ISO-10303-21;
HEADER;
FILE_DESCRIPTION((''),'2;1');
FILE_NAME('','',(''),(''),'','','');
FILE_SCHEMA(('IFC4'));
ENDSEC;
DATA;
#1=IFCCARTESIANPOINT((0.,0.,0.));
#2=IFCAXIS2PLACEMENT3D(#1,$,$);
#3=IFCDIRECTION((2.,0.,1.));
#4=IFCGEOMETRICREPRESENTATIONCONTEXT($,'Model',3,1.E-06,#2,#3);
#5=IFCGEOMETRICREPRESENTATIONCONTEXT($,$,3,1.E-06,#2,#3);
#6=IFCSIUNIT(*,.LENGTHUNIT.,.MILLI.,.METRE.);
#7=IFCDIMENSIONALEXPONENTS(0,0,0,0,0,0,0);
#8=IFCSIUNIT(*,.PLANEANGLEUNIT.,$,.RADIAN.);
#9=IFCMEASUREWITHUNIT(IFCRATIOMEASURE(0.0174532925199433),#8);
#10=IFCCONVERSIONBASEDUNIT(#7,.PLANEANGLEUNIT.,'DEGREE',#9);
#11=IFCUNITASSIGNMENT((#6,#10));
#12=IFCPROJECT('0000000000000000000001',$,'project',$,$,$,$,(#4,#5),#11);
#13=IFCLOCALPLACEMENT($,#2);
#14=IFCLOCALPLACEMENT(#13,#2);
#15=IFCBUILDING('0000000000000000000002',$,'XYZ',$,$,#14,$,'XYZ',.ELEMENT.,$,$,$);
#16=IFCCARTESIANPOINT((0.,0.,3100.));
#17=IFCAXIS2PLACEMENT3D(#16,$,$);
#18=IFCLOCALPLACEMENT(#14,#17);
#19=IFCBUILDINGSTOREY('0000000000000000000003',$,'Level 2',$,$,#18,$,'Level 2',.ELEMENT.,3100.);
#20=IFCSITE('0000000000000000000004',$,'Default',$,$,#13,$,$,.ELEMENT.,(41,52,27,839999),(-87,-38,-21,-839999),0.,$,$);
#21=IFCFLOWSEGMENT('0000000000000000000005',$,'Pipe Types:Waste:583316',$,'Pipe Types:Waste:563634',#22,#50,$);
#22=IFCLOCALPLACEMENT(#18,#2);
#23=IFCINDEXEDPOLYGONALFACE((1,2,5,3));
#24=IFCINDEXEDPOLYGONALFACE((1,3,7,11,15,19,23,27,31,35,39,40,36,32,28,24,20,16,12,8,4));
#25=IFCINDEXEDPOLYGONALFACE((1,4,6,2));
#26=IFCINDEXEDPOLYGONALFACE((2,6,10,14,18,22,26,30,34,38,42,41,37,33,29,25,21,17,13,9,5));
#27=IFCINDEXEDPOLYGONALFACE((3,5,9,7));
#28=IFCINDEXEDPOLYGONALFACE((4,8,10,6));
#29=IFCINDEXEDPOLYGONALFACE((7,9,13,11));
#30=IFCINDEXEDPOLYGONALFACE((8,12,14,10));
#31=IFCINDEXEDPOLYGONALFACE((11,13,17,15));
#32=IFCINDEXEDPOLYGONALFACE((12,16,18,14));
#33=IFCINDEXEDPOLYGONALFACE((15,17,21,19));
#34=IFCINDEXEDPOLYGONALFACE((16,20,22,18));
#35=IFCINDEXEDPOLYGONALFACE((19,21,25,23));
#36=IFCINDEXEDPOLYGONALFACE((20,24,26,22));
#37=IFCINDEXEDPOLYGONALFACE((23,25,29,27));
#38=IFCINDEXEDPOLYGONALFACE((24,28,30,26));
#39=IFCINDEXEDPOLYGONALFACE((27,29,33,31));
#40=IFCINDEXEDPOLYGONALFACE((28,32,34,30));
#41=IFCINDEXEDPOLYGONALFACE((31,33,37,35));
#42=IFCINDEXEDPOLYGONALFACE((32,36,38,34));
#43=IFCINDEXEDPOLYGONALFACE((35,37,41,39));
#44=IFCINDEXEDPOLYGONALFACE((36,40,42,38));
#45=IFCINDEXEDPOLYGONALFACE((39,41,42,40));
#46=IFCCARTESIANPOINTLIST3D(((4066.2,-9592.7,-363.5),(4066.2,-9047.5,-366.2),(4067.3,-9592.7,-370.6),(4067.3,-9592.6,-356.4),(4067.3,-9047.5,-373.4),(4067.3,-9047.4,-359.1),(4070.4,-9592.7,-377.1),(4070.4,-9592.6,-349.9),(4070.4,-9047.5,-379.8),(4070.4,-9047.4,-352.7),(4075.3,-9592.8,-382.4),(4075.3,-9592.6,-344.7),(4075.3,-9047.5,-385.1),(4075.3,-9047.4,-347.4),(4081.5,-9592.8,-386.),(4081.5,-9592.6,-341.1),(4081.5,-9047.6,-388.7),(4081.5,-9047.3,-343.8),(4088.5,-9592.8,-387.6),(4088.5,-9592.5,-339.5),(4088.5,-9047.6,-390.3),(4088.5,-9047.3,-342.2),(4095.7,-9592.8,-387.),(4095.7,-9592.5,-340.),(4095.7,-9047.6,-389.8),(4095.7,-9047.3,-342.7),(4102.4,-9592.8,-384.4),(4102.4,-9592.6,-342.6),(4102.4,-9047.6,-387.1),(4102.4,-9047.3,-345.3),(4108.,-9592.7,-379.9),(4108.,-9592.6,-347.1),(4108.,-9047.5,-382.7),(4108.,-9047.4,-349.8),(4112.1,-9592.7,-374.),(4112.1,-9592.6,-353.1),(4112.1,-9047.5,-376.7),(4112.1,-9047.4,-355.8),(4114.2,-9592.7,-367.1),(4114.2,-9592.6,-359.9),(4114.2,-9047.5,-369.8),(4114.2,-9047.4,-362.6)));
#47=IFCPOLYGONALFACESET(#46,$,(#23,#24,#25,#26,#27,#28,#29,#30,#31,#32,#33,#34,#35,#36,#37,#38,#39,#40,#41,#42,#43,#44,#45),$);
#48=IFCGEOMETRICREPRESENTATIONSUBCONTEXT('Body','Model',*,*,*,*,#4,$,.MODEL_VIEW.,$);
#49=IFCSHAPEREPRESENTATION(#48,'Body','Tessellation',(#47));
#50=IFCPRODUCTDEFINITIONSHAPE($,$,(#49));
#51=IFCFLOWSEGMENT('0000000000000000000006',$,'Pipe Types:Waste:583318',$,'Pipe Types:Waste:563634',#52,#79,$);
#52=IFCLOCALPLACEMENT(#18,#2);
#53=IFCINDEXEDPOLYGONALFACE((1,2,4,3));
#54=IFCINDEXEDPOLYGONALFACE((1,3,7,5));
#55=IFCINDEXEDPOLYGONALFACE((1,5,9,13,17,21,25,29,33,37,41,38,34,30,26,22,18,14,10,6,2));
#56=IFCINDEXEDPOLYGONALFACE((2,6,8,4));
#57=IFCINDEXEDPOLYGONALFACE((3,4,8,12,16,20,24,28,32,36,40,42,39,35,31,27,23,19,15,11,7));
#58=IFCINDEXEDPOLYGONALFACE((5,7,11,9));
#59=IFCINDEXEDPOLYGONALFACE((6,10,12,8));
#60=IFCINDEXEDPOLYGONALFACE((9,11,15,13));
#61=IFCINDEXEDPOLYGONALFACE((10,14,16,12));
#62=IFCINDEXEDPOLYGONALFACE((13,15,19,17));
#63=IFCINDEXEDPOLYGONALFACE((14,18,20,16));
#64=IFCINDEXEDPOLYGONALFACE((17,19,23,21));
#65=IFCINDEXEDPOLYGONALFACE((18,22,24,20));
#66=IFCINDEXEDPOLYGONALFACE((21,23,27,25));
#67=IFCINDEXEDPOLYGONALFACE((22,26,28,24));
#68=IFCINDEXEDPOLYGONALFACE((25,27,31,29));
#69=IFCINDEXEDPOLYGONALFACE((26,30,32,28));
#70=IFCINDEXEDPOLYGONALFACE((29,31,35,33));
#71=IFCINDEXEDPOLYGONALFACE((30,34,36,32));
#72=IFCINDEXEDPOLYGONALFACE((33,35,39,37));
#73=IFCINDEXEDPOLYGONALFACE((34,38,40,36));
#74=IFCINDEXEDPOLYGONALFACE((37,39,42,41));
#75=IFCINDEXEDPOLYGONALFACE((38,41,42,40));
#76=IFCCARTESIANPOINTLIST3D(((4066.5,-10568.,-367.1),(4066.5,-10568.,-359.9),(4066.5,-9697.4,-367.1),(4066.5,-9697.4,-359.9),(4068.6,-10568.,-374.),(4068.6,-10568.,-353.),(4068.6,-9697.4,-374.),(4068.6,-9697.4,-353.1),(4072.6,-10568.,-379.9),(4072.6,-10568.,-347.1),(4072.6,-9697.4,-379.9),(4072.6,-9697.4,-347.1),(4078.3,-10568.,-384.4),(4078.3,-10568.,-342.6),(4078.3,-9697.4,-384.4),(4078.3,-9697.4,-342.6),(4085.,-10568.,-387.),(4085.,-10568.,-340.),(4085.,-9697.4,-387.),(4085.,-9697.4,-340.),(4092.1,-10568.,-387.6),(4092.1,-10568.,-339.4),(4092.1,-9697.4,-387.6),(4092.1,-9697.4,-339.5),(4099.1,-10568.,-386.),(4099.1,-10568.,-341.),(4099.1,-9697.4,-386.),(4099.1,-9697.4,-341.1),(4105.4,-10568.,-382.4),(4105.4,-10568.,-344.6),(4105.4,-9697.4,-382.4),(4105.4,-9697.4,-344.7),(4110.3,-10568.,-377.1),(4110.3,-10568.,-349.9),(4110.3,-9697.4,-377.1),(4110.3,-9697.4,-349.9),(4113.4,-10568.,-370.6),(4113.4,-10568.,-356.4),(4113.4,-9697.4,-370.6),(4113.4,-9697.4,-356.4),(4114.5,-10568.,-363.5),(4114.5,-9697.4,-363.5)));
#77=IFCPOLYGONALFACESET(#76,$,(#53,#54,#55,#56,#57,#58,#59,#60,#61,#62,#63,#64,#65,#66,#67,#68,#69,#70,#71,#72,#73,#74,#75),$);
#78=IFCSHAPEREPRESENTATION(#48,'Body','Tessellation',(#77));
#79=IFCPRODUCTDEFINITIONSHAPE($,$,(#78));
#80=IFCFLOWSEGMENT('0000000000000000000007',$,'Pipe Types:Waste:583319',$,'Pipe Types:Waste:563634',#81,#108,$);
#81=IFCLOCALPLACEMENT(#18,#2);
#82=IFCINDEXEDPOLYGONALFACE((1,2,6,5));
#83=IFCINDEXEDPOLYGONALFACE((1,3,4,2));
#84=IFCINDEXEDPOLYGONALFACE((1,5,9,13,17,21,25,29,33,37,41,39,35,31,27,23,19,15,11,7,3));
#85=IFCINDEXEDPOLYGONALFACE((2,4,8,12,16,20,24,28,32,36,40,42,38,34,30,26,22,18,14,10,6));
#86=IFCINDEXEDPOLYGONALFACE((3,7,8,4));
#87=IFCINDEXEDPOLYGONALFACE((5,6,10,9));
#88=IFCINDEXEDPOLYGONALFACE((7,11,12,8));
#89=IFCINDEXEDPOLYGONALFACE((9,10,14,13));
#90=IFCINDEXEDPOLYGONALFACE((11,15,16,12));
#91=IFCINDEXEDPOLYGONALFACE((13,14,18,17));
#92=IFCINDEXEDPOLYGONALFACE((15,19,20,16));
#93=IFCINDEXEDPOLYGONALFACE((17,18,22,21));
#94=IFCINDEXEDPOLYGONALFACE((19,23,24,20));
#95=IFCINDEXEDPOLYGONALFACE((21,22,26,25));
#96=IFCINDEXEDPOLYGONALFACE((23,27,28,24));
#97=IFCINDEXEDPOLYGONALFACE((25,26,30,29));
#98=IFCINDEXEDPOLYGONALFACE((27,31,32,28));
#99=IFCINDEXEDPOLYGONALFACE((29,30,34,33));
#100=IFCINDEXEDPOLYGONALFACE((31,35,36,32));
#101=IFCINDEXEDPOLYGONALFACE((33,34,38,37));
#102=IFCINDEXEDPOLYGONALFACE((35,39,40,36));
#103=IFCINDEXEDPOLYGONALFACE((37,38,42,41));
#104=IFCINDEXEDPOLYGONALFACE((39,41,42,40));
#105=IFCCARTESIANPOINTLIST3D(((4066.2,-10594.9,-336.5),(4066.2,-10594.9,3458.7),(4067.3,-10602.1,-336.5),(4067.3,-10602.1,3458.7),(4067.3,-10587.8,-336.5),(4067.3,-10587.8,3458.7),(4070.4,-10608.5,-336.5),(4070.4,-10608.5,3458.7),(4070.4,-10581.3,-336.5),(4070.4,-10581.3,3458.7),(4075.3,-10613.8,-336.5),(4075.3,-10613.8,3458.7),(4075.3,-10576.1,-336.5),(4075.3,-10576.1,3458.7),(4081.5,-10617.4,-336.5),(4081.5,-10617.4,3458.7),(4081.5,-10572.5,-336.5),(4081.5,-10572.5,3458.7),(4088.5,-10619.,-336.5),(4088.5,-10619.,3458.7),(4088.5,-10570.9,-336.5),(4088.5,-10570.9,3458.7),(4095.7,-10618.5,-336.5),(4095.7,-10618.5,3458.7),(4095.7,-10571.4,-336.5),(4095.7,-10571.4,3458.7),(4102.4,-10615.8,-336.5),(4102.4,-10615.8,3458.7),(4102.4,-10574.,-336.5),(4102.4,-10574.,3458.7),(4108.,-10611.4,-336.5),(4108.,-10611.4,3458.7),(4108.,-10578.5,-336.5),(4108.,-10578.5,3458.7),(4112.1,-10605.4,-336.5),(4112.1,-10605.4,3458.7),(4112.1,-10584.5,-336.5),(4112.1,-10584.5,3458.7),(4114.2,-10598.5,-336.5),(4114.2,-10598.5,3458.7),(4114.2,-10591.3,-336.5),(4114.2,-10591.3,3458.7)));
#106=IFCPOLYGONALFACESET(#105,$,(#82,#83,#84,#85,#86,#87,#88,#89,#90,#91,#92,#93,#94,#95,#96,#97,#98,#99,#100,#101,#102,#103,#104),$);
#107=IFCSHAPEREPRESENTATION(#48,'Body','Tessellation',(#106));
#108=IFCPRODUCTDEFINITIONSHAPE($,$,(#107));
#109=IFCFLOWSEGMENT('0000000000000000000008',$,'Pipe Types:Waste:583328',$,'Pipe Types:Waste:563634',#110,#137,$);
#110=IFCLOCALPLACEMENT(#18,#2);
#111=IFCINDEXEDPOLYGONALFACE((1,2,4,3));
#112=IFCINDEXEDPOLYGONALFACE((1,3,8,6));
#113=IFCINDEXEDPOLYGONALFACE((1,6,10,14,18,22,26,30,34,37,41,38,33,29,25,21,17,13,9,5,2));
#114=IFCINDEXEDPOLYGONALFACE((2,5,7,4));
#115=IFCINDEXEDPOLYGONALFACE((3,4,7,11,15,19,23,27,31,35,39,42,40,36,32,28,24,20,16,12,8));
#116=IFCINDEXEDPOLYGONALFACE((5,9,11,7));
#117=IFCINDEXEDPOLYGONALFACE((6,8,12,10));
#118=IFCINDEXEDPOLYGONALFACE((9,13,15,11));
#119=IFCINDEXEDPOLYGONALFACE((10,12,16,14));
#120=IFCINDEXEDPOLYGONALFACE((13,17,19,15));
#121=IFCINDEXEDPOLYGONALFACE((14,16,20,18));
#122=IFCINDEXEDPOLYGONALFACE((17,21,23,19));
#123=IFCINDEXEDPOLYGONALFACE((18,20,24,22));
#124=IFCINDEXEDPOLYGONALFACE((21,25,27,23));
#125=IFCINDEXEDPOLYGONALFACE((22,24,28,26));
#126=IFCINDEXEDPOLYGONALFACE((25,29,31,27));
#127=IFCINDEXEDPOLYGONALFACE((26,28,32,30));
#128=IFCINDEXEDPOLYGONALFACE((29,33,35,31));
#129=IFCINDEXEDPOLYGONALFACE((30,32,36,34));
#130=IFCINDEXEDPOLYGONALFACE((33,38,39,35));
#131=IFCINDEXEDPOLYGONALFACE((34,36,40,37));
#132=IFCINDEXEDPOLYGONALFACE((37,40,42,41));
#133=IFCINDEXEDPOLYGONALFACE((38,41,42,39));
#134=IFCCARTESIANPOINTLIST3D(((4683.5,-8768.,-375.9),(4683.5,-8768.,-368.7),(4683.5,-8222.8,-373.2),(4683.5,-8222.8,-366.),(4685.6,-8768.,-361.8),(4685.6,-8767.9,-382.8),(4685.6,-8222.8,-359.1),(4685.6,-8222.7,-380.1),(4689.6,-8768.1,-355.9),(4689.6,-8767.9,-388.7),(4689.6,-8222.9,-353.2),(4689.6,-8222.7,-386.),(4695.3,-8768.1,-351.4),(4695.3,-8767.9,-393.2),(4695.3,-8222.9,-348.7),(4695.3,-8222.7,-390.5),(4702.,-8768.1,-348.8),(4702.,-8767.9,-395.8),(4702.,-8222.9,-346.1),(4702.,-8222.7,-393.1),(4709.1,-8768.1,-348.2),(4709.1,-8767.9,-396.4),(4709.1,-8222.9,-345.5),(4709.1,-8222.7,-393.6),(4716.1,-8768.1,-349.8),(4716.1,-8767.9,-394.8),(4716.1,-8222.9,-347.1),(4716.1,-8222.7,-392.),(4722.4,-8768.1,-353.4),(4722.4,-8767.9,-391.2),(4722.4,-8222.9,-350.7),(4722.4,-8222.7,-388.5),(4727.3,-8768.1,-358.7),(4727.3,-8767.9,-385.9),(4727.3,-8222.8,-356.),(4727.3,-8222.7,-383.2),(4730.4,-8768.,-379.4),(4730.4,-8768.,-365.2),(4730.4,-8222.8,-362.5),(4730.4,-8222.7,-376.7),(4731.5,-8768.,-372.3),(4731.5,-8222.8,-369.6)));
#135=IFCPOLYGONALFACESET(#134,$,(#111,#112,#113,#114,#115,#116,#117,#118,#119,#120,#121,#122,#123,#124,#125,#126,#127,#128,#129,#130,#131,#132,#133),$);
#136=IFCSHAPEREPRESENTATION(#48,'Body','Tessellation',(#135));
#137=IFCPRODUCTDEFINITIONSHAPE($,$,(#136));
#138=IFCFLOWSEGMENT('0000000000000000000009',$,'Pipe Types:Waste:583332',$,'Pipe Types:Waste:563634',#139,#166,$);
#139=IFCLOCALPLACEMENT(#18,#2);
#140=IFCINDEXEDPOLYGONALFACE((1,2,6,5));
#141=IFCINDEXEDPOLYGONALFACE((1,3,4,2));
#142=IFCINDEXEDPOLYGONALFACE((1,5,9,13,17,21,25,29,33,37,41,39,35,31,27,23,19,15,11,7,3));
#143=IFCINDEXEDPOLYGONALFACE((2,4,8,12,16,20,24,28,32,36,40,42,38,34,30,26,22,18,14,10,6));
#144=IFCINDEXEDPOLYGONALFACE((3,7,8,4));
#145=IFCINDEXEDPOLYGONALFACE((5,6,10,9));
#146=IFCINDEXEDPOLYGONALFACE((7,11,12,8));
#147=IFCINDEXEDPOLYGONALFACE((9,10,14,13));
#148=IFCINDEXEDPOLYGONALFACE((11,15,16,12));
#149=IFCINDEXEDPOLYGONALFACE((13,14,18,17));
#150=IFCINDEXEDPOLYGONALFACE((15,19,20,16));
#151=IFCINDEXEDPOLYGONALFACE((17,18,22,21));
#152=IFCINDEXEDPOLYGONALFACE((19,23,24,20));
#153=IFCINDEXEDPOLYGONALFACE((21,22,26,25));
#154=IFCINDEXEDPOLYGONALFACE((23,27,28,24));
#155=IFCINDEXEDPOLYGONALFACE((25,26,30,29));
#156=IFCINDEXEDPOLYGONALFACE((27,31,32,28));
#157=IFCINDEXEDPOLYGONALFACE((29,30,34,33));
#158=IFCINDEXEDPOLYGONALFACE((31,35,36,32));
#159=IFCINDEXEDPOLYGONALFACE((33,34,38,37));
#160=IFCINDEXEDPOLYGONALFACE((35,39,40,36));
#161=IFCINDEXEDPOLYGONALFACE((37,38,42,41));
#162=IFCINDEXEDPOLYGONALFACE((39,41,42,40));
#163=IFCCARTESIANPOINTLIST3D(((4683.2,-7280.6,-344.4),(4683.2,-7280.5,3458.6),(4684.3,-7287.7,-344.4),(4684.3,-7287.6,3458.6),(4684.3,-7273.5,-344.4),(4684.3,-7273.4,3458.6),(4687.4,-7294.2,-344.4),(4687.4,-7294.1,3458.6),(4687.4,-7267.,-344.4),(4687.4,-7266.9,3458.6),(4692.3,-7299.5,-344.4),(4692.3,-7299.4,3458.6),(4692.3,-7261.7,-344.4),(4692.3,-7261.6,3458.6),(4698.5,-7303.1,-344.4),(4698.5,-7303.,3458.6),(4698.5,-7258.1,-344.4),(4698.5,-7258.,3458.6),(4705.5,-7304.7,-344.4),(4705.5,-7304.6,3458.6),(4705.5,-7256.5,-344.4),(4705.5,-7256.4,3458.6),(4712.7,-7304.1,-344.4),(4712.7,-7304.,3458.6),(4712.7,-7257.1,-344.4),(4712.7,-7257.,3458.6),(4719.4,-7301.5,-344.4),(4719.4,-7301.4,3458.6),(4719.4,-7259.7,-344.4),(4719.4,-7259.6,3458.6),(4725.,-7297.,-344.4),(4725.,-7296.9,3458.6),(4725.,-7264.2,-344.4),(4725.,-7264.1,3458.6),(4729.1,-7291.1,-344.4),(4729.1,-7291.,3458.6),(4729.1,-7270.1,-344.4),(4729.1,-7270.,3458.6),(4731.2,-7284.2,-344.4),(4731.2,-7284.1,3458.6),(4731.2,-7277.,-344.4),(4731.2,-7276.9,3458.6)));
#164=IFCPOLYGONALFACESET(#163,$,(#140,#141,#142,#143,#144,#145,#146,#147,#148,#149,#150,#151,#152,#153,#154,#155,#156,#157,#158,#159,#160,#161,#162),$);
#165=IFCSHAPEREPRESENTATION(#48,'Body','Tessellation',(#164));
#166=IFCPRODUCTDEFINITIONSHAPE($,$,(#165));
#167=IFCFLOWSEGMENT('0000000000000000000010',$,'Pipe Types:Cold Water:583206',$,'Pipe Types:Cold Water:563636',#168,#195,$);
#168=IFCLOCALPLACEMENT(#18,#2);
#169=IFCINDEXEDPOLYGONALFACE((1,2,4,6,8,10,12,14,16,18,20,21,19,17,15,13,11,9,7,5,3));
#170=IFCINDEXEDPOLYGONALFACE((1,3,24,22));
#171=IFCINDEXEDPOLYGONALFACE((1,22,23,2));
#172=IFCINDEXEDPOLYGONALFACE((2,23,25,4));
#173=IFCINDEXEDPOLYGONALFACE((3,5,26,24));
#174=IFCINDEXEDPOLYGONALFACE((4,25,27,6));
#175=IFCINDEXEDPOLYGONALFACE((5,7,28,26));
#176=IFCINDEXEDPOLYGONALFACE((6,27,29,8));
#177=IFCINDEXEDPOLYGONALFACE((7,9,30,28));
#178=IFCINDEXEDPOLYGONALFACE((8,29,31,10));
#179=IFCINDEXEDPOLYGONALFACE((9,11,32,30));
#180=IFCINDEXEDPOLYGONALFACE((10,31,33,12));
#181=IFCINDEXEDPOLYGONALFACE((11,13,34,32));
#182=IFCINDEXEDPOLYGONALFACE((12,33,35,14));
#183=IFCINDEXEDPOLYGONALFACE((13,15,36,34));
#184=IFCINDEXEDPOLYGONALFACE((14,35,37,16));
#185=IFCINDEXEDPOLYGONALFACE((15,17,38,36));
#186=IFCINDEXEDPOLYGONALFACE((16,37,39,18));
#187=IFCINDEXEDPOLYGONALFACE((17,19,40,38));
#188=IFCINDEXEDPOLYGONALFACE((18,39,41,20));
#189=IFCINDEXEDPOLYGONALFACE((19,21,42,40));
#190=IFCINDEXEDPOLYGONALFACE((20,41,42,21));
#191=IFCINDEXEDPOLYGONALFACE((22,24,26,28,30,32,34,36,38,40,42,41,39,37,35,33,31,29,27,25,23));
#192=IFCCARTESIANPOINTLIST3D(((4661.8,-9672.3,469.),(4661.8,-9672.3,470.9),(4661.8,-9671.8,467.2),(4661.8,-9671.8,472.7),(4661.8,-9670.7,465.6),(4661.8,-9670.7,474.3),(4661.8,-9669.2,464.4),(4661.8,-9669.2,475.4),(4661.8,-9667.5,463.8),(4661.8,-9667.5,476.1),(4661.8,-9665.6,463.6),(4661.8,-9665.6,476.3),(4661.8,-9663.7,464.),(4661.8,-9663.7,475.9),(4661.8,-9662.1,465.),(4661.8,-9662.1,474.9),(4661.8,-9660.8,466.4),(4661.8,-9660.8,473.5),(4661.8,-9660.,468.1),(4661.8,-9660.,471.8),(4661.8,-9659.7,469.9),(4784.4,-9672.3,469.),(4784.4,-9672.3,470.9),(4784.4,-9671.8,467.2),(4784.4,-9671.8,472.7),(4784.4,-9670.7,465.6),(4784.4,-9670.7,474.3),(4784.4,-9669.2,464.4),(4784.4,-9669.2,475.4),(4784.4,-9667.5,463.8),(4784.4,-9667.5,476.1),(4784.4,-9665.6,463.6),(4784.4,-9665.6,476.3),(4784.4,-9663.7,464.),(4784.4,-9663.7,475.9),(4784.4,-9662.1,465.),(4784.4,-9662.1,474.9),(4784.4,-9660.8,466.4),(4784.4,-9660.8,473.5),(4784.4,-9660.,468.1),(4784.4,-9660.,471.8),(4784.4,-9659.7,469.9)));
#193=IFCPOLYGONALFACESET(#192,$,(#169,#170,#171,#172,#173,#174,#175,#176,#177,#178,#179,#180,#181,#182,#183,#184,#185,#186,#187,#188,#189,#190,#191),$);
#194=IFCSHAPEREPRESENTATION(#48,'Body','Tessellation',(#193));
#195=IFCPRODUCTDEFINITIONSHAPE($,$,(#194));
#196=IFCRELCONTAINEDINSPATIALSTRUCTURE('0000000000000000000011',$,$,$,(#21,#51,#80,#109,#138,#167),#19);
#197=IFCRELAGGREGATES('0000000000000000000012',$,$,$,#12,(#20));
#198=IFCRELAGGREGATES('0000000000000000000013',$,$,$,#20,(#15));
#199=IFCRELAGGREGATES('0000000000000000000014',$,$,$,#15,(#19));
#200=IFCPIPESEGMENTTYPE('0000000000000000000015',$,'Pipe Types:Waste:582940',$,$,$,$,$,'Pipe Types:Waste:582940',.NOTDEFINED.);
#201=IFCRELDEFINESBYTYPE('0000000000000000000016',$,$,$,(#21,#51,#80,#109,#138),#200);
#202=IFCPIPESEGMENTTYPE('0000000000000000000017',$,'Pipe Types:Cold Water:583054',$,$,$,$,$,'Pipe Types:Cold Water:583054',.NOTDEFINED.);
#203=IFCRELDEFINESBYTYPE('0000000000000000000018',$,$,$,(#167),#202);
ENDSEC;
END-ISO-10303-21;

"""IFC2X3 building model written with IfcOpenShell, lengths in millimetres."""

from ifc_helpers import new_model, entity, si_unit, converted_unit, direction, frame, frame_2d, origin, origin_2d_with_axis, place, context, subcontext, project, spatial, circle, extrude, type_object, element, save


model = new_model("IFC2X3")

# Units and contexts
model_context = context("Model", 3, precision=1e-06, world=origin(), true_north=direction((2.0, 0.0, 1.0)))
context_of_model = context(None, 3, precision=1e-06, world=origin(), true_north=direction((2.0, 0.0, 1.0)))
body_context = subcontext(model_context, "Body", "Model", "MODEL_VIEW")
ifc_project = project(units=[si_unit("LENGTHUNIT", "METRE", prefix="MILLI"), converted_unit("PLANEANGLEUNIT", "DEGREE", entity("IfcRatioMeasure", 0.0174532925199433), si_unit("PLANEANGLEUNIT", "RADIAN"), dimensions=[0, 0, 0, 0, 0, 0, 0])], contexts=[model_context, context_of_model])

# Site, building, storey
site_placement = place(None, origin())
site = spatial("IfcSite", under=ifc_project, at=site_placement, Name="Default", CompositionType="ELEMENT", RefLatitude=(41, 52, 27, 839999), RefLongitude=(-87, -38, -21, -839999), RefElevation=0.0)
building_placement = place(site_placement, origin())
building = spatial("IfcBuilding", under=site, at=building_placement, Name="XYZ", LongName="XYZ", CompositionType="ELEMENT")
storey_placement = place(building_placement, frame((0.0, 0.0, 3100.0)))
storey = spatial("IfcBuildingStorey", under=building, at=storey_placement, Name="Level 2", LongName="Level 2", CompositionType="ELEMENT", Elevation=3100.0)

# Flow segments
pipe_segment_type_1 = type_object("IfcPipeSegmentType", Name="Pipe Types:Waste:582940", ElementType="Pipe Types:Waste:582940", PredefinedType="NOTDEFINED")
flow_segment_1_placement = place(storey_placement, origin())
element("IfcFlowSegment", 1, at=flow_segment_1_placement, inside=storey, type_object=pipe_segment_type_1, Name="Pipe Types:Waste:583316", ObjectType="Pipe Types:Waste:563634", context=body_context, shape_type="SweptSolid", body=[
    extrude(circle(Radius=24.1, at=origin_2d_with_axis()), frame((4090.3, -9047.5, -366.2), z_axis=(0.0, -0.999988, 0.005), x_axis=(-1.0, 0.0, 0.0)), (0.0, 0.0, 1.0), 545.2),
])
flow_segment_2_placement = place(storey_placement, origin())
element("IfcFlowSegment", 2, at=flow_segment_2_placement, inside=storey, type_object=pipe_segment_type_1, Name="Pipe Types:Waste:583318", ObjectType="Pipe Types:Waste:563634", context=body_context, shape_type="SweptSolid", body=[
    extrude(circle(Radius=24.1, at=frame_2d((0.0, 0.0), x_axis=(1.0, 0.0))), frame((4090.3, -10568.0, -363.5), z_axis=(0.0, 1.0, -0.000022), x_axis=(1.0, 0.0, 0.0)), (0.0, 0.0, 1.0), 870.5),
])
flow_segment_3_placement = place(storey_placement, origin())
element("IfcFlowSegment", 3, at=flow_segment_3_placement, inside=storey, type_object=pipe_segment_type_1, Name="Pipe Types:Waste:583319", ObjectType="Pipe Types:Waste:563634", context=body_context, shape_type="SweptSolid", body=[
    extrude(circle(Radius=24.1, at=origin_2d_with_axis()), frame((4090.3, -10594.9, -336.5), z_axis=(0.0, 0.0, 1.0), x_axis=(-1.0, 0.0, 0.0)), (0.0, 0.0, 1.0), 3795.2),
])
flow_segment_4_placement = place(storey_placement, origin())
element("IfcFlowSegment", 4, at=flow_segment_4_placement, inside=storey, type_object=pipe_segment_type_1, Name="Pipe Types:Waste:583328", ObjectType="Pipe Types:Waste:563634", context=body_context, shape_type="SweptSolid", body=[
    extrude(circle(Radius=24.1, at=frame_2d((0.0, 0.0), x_axis=(1.0, 0.0))), frame((4707.3, -8768.0, -372.3), z_axis=(0.0, 0.999988, 0.005), x_axis=(1.0, 0.0, 0.0)), (0.0, 0.0, 1.0), 545.2),
])
flow_segment_5_placement = place(storey_placement, origin())
element("IfcFlowSegment", 5, at=flow_segment_5_placement, inside=storey, type_object=pipe_segment_type_1, Name="Pipe Types:Waste:583332", ObjectType="Pipe Types:Waste:563634", context=body_context, shape_type="SweptSolid", body=[
    extrude(circle(Radius=24.1, at=origin_2d_with_axis()), frame((4707.3, -7280.6, -344.4), z_axis=(0.0, 0.000027, 1.0), x_axis=(-1.0, 0.0, 0.0)), (0.0, 0.0, 1.0), 3803.0),
])
pipe_segment_type_2 = type_object("IfcPipeSegmentType", Name="Pipe Types:Cold Water:583054", ElementType="Pipe Types:Cold Water:583054", PredefinedType="NOTDEFINED")
flow_segment_6_placement = place(storey_placement, origin())
element("IfcFlowSegment", 6, at=flow_segment_6_placement, inside=storey, type_object=pipe_segment_type_2, Name="Pipe Types:Cold Water:583206", ObjectType="Pipe Types:Cold Water:563636", context=body_context, shape_type="SweptSolid", body=[
    extrude(circle(Radius=6.3, at=frame_2d((0.0, 0.0), x_axis=(1.0, 0.0))), frame((4661.8, -9666.1, 469.9), z_axis=(1.0, 0.0, 0.0), x_axis=(0.0, 1.0, 0.0)), (0.0, 0.0, 1.0), 122.5),
])

save(model, "model.ifc")
